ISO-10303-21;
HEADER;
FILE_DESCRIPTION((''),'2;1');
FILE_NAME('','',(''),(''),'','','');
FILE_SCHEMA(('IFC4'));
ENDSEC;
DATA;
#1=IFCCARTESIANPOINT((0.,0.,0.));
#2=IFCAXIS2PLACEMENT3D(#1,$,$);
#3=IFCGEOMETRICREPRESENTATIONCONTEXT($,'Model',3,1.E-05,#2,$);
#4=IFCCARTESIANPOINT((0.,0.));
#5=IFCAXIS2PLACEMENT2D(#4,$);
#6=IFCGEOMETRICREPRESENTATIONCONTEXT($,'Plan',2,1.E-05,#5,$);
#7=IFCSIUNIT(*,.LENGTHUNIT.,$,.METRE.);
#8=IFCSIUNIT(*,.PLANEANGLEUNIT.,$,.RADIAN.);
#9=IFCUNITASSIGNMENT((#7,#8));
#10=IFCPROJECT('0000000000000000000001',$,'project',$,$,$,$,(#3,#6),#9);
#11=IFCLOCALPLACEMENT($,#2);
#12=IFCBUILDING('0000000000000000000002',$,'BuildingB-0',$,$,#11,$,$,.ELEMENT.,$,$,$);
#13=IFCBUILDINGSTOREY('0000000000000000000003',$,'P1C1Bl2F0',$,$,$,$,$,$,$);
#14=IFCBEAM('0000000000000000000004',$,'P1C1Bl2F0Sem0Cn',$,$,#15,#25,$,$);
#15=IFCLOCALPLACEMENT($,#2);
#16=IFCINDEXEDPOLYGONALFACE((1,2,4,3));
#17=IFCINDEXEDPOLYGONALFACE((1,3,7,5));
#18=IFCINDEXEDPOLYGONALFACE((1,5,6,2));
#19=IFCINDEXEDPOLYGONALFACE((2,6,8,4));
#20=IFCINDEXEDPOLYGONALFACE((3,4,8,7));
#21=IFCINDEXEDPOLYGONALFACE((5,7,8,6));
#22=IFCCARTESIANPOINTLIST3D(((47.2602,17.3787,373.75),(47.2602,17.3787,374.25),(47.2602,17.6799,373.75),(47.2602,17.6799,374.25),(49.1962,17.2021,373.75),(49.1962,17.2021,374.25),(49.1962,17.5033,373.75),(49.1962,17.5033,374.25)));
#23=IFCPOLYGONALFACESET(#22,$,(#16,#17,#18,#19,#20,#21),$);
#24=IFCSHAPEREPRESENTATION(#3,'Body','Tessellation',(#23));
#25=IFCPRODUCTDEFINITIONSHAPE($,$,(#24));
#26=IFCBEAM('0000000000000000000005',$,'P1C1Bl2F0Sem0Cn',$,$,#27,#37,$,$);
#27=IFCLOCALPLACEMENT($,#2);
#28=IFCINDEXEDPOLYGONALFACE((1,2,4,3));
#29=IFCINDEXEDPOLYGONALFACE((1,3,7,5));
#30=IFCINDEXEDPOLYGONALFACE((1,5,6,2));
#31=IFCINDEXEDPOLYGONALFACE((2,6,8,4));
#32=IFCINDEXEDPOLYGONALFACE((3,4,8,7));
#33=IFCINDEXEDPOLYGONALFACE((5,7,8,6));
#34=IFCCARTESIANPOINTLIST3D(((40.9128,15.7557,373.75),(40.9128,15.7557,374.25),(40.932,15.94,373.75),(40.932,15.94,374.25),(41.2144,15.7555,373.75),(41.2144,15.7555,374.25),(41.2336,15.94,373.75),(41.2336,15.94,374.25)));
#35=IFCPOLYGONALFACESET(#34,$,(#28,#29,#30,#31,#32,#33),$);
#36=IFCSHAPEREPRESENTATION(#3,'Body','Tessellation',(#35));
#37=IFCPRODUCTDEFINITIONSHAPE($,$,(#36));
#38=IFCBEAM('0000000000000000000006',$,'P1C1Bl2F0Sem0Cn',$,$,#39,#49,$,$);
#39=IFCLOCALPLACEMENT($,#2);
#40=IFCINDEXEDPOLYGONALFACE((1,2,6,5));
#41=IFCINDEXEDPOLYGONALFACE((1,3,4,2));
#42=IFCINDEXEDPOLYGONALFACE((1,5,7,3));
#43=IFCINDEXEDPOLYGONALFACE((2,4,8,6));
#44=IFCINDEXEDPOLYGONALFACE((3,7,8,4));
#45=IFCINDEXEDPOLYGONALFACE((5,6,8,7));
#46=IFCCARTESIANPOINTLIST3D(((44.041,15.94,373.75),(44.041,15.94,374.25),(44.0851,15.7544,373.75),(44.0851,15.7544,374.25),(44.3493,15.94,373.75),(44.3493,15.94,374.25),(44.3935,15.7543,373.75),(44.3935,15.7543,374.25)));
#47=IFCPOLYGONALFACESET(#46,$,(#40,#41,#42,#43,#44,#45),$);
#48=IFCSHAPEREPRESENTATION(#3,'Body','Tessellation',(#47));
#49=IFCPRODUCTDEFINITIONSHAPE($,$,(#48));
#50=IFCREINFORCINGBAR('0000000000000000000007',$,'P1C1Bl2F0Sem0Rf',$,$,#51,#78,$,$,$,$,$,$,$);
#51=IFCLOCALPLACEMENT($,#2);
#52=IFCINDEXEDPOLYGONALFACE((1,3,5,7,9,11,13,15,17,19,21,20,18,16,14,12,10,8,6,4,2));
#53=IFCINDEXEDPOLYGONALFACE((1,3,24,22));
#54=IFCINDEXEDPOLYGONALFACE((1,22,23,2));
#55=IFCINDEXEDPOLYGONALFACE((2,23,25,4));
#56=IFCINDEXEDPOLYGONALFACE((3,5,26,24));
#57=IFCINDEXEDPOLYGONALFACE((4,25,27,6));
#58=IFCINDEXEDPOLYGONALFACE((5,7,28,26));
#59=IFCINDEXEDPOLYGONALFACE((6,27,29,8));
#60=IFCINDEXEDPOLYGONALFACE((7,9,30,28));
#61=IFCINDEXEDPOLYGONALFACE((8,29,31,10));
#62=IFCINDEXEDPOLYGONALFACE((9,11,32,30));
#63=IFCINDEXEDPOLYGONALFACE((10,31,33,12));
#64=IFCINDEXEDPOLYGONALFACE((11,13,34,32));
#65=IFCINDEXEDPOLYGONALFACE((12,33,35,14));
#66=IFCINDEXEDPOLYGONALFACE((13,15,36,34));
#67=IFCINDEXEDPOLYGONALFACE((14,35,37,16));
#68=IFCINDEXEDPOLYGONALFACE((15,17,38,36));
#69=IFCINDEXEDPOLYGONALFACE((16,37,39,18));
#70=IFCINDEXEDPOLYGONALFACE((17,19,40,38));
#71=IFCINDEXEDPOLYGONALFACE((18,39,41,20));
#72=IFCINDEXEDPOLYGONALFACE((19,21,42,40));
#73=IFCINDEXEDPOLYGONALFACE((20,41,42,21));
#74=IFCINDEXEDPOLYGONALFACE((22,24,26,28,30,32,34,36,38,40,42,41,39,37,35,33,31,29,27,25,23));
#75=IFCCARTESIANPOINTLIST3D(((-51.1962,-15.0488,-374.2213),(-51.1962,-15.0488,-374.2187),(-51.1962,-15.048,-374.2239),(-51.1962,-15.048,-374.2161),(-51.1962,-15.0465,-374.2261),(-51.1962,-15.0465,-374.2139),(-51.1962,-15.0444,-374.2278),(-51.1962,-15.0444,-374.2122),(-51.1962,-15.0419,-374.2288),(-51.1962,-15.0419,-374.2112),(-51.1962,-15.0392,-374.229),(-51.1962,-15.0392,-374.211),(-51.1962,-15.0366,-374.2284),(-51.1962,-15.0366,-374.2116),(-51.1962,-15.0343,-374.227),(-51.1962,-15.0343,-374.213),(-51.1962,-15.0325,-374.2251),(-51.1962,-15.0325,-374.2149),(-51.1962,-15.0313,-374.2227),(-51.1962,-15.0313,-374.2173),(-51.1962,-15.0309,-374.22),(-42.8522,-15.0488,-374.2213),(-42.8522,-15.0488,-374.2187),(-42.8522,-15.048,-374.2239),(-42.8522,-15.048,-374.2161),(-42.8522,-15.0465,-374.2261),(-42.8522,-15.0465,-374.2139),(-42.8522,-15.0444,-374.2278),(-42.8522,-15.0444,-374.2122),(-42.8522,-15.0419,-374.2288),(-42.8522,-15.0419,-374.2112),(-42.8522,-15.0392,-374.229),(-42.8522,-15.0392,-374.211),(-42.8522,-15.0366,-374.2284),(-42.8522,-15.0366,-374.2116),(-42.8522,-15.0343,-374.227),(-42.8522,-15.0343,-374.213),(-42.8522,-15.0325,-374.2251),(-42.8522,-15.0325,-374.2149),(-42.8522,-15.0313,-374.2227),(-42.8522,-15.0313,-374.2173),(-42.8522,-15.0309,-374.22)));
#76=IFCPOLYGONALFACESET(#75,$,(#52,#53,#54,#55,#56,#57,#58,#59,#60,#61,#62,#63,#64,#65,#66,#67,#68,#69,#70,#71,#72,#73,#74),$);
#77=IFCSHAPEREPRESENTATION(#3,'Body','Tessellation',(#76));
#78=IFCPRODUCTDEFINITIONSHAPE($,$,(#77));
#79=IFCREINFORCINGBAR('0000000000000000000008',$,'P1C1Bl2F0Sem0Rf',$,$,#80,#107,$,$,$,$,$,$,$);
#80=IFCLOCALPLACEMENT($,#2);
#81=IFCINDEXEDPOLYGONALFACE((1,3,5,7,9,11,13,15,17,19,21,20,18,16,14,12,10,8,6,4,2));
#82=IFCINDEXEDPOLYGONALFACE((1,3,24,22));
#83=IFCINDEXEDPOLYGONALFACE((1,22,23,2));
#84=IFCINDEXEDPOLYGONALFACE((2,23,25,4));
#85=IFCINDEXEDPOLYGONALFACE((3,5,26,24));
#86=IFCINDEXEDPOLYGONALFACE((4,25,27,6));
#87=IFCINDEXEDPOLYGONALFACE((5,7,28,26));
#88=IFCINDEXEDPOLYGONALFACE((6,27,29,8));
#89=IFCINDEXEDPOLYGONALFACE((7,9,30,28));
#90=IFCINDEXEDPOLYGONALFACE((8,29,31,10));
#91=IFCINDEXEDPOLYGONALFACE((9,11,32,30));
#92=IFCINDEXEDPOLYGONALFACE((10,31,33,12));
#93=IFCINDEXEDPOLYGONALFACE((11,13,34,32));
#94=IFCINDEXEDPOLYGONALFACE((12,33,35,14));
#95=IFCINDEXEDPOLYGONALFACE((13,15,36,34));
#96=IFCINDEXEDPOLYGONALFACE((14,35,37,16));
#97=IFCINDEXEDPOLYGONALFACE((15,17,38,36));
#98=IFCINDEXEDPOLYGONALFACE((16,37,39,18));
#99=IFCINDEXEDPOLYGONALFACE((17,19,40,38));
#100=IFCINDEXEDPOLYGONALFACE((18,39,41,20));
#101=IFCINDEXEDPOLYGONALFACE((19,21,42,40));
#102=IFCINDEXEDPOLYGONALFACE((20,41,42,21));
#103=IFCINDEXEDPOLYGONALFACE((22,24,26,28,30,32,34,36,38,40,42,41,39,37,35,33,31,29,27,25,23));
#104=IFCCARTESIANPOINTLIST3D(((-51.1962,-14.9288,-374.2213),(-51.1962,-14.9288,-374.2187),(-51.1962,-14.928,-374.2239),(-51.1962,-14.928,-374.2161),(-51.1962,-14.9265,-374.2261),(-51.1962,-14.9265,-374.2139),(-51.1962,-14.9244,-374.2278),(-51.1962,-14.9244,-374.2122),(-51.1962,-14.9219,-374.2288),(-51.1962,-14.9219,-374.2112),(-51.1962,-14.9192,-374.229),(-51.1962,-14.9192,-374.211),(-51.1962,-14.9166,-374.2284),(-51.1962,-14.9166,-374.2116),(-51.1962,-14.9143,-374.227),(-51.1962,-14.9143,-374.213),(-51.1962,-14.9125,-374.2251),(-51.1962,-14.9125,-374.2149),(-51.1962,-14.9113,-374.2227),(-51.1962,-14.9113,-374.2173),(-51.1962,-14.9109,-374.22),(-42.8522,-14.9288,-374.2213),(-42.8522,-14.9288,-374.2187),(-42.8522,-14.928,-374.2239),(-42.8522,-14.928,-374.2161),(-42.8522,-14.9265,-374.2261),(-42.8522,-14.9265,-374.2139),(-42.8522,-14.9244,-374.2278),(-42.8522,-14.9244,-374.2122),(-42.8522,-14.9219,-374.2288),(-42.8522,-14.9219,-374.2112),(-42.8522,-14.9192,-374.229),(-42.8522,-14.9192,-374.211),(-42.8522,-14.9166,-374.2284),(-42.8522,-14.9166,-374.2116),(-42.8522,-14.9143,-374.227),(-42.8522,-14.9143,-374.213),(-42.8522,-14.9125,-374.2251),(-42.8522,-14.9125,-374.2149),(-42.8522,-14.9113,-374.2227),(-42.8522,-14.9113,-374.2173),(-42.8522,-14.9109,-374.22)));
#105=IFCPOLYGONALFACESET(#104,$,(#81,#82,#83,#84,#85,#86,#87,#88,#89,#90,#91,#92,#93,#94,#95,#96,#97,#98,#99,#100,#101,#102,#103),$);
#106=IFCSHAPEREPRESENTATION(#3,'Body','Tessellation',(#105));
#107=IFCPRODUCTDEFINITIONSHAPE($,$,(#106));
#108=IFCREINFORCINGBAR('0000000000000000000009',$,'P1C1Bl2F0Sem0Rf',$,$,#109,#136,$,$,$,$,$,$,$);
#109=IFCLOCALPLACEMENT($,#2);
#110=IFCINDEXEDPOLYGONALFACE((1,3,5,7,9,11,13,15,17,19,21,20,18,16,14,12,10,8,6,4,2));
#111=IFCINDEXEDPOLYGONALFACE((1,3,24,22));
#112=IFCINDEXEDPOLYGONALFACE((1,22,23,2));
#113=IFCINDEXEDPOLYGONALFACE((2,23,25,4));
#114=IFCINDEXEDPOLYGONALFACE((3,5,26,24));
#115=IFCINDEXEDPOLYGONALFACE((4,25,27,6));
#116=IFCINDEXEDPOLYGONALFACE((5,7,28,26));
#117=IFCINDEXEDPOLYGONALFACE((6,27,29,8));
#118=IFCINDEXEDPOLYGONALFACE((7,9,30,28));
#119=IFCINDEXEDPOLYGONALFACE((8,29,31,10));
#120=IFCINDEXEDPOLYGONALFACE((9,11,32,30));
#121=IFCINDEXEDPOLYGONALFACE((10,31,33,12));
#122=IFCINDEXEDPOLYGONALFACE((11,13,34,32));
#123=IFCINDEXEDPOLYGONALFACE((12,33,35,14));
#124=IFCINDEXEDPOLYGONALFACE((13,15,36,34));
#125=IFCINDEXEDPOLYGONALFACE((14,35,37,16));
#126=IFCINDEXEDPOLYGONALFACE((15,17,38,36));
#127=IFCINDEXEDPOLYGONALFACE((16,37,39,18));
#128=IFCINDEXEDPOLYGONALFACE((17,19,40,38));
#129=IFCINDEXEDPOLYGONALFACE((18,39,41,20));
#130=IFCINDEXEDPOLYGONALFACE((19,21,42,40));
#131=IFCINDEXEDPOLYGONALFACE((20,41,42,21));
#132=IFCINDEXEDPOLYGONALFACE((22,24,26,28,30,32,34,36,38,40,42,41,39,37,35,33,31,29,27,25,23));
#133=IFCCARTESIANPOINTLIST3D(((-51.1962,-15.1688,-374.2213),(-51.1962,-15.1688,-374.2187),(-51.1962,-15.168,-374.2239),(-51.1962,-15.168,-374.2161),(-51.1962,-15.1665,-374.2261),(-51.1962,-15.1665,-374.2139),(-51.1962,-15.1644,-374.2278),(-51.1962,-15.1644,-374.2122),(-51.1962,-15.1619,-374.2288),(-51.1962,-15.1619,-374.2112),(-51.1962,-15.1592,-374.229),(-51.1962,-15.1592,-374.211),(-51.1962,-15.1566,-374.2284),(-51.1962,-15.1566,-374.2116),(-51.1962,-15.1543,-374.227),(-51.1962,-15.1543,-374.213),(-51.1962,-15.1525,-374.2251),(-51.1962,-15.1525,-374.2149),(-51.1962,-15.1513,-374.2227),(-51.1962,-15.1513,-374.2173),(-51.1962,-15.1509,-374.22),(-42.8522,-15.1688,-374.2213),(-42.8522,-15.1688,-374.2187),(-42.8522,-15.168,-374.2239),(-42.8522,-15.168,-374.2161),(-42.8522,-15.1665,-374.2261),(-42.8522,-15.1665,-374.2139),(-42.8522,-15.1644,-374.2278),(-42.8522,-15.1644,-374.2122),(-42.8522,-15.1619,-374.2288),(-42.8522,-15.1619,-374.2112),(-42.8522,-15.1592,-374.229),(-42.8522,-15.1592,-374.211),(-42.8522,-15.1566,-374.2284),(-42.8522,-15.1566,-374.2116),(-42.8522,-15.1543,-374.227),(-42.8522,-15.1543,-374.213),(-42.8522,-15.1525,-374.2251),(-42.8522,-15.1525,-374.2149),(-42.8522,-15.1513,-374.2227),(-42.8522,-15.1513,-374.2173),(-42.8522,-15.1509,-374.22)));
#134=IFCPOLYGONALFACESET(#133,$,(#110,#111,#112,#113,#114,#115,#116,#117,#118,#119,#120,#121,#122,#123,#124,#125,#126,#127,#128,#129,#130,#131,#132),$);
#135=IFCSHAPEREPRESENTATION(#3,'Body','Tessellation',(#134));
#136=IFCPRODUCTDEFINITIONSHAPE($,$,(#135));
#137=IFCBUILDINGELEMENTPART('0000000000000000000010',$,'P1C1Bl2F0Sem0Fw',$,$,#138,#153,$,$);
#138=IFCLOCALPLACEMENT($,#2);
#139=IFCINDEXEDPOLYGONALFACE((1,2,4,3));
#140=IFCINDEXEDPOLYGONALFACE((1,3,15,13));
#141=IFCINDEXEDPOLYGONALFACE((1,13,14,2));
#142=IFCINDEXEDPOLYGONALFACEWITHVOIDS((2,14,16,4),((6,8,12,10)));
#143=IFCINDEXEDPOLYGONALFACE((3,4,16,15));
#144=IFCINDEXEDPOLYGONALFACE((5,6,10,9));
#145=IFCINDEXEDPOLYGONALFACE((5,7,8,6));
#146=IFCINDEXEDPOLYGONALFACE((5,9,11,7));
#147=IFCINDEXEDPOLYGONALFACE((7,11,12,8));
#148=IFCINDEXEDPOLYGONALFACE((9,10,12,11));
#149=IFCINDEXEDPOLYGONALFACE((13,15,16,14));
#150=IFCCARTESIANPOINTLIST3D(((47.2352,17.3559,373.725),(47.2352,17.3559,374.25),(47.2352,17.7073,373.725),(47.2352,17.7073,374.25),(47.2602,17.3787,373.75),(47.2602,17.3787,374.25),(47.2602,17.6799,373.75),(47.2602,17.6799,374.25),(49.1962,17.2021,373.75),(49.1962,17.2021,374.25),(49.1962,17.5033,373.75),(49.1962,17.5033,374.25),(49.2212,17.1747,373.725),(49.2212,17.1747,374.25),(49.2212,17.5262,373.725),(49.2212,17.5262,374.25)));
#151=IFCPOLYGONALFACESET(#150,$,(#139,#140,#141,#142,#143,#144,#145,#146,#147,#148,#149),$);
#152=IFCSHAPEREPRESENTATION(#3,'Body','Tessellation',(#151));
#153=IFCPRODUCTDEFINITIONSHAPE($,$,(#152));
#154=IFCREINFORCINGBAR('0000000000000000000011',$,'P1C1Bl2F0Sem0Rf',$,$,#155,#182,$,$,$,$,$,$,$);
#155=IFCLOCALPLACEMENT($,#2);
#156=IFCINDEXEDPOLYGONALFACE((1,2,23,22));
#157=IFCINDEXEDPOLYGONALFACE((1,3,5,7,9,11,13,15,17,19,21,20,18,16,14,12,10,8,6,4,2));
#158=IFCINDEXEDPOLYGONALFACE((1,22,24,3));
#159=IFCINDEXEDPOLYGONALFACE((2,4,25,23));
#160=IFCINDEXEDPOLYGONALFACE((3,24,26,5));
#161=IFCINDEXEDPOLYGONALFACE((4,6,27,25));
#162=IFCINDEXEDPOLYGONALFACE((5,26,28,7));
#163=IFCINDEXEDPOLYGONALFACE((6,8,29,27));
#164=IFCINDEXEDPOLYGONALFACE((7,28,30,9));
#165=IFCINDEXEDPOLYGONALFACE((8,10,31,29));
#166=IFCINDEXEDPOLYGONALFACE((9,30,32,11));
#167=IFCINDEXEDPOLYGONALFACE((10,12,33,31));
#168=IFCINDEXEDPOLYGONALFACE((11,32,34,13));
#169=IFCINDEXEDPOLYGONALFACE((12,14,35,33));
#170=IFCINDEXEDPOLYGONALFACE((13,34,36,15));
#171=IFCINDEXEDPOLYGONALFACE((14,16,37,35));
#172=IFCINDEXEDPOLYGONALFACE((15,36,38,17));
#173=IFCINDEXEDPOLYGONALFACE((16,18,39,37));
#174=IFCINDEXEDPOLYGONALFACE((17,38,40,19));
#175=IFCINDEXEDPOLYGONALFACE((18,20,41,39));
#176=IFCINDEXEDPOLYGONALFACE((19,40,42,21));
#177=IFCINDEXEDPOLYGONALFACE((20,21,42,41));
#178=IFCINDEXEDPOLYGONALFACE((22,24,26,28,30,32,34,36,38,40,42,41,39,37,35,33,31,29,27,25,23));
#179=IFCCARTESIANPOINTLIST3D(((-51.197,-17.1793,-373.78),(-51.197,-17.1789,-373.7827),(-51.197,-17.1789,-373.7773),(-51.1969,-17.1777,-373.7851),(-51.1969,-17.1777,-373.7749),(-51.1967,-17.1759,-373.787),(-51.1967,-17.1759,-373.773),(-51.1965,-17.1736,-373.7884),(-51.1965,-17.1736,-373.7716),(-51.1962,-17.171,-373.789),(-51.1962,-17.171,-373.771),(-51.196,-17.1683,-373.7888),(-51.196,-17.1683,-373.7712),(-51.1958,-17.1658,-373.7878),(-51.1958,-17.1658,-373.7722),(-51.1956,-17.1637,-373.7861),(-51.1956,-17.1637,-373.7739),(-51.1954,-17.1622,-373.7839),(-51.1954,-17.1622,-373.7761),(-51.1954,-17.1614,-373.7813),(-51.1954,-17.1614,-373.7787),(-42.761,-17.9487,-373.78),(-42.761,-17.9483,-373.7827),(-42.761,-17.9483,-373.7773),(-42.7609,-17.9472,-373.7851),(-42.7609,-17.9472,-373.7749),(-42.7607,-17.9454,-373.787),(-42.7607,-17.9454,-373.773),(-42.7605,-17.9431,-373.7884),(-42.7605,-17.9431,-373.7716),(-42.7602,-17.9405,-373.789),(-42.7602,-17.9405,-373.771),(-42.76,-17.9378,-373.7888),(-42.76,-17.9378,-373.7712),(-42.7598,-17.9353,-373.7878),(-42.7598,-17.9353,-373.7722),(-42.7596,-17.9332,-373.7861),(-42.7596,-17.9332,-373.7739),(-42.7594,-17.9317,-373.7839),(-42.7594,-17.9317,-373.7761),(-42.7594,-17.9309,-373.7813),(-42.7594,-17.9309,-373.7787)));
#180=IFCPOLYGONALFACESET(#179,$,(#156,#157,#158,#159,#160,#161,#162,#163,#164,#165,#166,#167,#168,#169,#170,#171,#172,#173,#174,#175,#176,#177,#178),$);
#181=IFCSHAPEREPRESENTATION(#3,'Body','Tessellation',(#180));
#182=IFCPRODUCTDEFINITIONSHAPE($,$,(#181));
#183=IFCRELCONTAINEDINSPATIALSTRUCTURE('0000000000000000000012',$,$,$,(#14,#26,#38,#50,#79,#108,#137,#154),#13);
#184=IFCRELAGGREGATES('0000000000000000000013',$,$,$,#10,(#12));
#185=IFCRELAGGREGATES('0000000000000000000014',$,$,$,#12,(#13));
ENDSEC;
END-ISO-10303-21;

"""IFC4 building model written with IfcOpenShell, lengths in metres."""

from ifc_helpers import new_model, entity, si_unit, origin, origin_2d, place, context, project, spatial, polyline, outline, extrude, element, save


model = new_model("IFC4")

# Units and contexts
model_context = context("Model", 3, precision=1e-05, world=origin())
plan_context = context("Plan", 2, precision=1e-05, world=origin_2d())
ifc_project = project(units=[si_unit("LENGTHUNIT", "METRE"), si_unit("PLANEANGLEUNIT", "RADIAN")], contexts=[model_context, plan_context])

# Building, storey
building_placement = place(None, origin())
building = spatial("IfcBuilding", under=ifc_project, at=building_placement, Name="BuildingB-0", CompositionType="ELEMENT")
storey = spatial("IfcBuildingStorey", under=building, Name="P1C1Bl2F0")

# Beams
element("IfcBeam", 1, inside=storey, Name="P1C1Bl2F0Sem0Cn", context=model_context, shape_type="SweptSolid", body=[
    extrude(outline(polyline([(47.2602, 17.3787, 373.75), (47.2602, 17.6799, 373.75), (49.1962, 17.5033, 373.75), (49.1962, 17.2021, 373.75), (47.2602, 17.3787, 373.75)])), None, (0.0, 0.0, 1.0), 0.5),
])
element("IfcBeam", 2, inside=storey, Name="P1C1Bl2F0Sem0Cn", context=model_context, shape_type="SweptSolid", body=[
    extrude(outline(polyline([(40.9128, 15.7557, 373.75), (40.932, 15.94, 373.75), (41.2336, 15.94, 373.75), (41.2144, 15.7555, 373.75), (40.9128, 15.7557, 373.75)])), None, (0.0, 0.0, 1.0), 0.5),
])
element("IfcBeam", 3, inside=storey, Name="P1C1Bl2F0Sem0Cn", context=model_context, shape_type="SweptSolid", body=[
    extrude(outline(polyline([(44.0851, 15.7544, 373.75), (44.041, 15.94, 373.75), (44.3493, 15.94, 373.75), (44.3935, 15.7543, 373.75), (44.0851, 15.7544, 373.75)])), None, (0.0, 0.0, 1.0), 0.5),
])

# Reinforcing bars
element("IfcReinforcingBar", 4, inside=storey, Name="P1C1Bl2F0Sem0Rf", context=model_context, shape_type="SweptSolid", body=[
    entity("IfcSurfaceCurveSweptAreaSolid", entity("IfcCircleProfileDef", "AREA", None, None, 0.009), None, entity("IfcPolyline", [entity("IfcCartesianPoint", [42.8522, 15.0399, 374.22]), entity("IfcCartesianPoint", [51.1962, 15.0399, 374.22])]), None, None, entity("IfcPlane", entity("IfcAxis2Placement3D", entity("IfcCartesianPoint", [42.8522, 15.0399, 374.22]), entity("IfcDirection", [0.0, 0.0, 1.0]), entity("IfcDirection", [1.0, 0.0, 0.0])))),
])
element("IfcReinforcingBar", 5, inside=storey, Name="P1C1Bl2F0Sem0Rf", context=model_context, shape_type="SweptSolid", body=[
    entity("IfcSurfaceCurveSweptAreaSolid", entity("IfcCircleProfileDef", "AREA", None, None, 0.009), None, entity("IfcPolyline", [entity("IfcCartesianPoint", [42.8522, 14.9199, 374.22]), entity("IfcCartesianPoint", [51.1962, 14.9199, 374.22])]), None, None, entity("IfcPlane", entity("IfcAxis2Placement3D", entity("IfcCartesianPoint", [42.8522, 14.9199, 374.22]), entity("IfcDirection", [0.0, 0.0, 1.0]), entity("IfcDirection", [1.0, 0.0, 0.0])))),
])
element("IfcReinforcingBar", 6, inside=storey, Name="P1C1Bl2F0Sem0Rf", context=model_context, shape_type="SweptSolid", body=[
    entity("IfcSurfaceCurveSweptAreaSolid", entity("IfcCircleProfileDef", "AREA", None, None, 0.009), None, entity("IfcPolyline", [entity("IfcCartesianPoint", [42.8522, 15.1599, 374.22]), entity("IfcCartesianPoint", [51.1962, 15.1599, 374.22])]), None, None, entity("IfcPlane", entity("IfcAxis2Placement3D", entity("IfcCartesianPoint", [42.8522, 15.1599, 374.22]), entity("IfcDirection", [0.0, 0.0, 1.0]), entity("IfcDirection", [1.0, 0.0, 0.0])))),
])

# Building element part, opening
building_element_part_1 = element("IfcBuildingElementPart", 7, inside=storey, Name="P1C1Bl2F0Sem0Fw", context=model_context, shape_type="SweptSolid", body=[
    extrude(outline(polyline([(47.2352, 17.3559, 373.725), (47.2352, 17.7073, 373.725), (49.2212, 17.5262, 373.725), (49.2212, 17.1747, 373.725), (47.2352, 17.3559, 373.725)])), None, (0.0, 0.0, 1.0), 0.525),
])
element("IfcOpeningElement", 8, inside=storey, cuts=building_element_part_1, context=model_context, shape_type="SweptSolid", body=[
    extrude(outline(polyline([(47.2602, 17.3787, 373.75), (47.2602, 17.6799, 373.75), (49.1962, 17.5033, 373.75), (49.1962, 17.2021, 373.75), (47.2602, 17.3787, 373.75)])), None, (0.0, 0.0, 1.0), 0.5),
])

# Reinforcing bar
element("IfcReinforcingBar", 9, inside=storey, Name="P1C1Bl2F0Sem0Rf", context=model_context, shape_type="SweptSolid", body=[
    entity("IfcSurfaceCurveSweptAreaSolid", entity("IfcCircleProfileDef", "AREA", None, None, 0.009), None, entity("IfcPolyline", [entity("IfcCartesianPoint", [51.1962, 17.1703, 373.78]), entity("IfcCartesianPoint", [42.7602, 17.9398, 373.78])]), None, None, entity("IfcPlane", entity("IfcAxis2Placement3D", entity("IfcCartesianPoint", [51.1962, 17.1703, 373.78]), entity("IfcDirection", [0.0, 0.0, 1.0]), entity("IfcDirection", [1.0, 0.0, 0.0])))),
])

save(model, "model.ifc")
